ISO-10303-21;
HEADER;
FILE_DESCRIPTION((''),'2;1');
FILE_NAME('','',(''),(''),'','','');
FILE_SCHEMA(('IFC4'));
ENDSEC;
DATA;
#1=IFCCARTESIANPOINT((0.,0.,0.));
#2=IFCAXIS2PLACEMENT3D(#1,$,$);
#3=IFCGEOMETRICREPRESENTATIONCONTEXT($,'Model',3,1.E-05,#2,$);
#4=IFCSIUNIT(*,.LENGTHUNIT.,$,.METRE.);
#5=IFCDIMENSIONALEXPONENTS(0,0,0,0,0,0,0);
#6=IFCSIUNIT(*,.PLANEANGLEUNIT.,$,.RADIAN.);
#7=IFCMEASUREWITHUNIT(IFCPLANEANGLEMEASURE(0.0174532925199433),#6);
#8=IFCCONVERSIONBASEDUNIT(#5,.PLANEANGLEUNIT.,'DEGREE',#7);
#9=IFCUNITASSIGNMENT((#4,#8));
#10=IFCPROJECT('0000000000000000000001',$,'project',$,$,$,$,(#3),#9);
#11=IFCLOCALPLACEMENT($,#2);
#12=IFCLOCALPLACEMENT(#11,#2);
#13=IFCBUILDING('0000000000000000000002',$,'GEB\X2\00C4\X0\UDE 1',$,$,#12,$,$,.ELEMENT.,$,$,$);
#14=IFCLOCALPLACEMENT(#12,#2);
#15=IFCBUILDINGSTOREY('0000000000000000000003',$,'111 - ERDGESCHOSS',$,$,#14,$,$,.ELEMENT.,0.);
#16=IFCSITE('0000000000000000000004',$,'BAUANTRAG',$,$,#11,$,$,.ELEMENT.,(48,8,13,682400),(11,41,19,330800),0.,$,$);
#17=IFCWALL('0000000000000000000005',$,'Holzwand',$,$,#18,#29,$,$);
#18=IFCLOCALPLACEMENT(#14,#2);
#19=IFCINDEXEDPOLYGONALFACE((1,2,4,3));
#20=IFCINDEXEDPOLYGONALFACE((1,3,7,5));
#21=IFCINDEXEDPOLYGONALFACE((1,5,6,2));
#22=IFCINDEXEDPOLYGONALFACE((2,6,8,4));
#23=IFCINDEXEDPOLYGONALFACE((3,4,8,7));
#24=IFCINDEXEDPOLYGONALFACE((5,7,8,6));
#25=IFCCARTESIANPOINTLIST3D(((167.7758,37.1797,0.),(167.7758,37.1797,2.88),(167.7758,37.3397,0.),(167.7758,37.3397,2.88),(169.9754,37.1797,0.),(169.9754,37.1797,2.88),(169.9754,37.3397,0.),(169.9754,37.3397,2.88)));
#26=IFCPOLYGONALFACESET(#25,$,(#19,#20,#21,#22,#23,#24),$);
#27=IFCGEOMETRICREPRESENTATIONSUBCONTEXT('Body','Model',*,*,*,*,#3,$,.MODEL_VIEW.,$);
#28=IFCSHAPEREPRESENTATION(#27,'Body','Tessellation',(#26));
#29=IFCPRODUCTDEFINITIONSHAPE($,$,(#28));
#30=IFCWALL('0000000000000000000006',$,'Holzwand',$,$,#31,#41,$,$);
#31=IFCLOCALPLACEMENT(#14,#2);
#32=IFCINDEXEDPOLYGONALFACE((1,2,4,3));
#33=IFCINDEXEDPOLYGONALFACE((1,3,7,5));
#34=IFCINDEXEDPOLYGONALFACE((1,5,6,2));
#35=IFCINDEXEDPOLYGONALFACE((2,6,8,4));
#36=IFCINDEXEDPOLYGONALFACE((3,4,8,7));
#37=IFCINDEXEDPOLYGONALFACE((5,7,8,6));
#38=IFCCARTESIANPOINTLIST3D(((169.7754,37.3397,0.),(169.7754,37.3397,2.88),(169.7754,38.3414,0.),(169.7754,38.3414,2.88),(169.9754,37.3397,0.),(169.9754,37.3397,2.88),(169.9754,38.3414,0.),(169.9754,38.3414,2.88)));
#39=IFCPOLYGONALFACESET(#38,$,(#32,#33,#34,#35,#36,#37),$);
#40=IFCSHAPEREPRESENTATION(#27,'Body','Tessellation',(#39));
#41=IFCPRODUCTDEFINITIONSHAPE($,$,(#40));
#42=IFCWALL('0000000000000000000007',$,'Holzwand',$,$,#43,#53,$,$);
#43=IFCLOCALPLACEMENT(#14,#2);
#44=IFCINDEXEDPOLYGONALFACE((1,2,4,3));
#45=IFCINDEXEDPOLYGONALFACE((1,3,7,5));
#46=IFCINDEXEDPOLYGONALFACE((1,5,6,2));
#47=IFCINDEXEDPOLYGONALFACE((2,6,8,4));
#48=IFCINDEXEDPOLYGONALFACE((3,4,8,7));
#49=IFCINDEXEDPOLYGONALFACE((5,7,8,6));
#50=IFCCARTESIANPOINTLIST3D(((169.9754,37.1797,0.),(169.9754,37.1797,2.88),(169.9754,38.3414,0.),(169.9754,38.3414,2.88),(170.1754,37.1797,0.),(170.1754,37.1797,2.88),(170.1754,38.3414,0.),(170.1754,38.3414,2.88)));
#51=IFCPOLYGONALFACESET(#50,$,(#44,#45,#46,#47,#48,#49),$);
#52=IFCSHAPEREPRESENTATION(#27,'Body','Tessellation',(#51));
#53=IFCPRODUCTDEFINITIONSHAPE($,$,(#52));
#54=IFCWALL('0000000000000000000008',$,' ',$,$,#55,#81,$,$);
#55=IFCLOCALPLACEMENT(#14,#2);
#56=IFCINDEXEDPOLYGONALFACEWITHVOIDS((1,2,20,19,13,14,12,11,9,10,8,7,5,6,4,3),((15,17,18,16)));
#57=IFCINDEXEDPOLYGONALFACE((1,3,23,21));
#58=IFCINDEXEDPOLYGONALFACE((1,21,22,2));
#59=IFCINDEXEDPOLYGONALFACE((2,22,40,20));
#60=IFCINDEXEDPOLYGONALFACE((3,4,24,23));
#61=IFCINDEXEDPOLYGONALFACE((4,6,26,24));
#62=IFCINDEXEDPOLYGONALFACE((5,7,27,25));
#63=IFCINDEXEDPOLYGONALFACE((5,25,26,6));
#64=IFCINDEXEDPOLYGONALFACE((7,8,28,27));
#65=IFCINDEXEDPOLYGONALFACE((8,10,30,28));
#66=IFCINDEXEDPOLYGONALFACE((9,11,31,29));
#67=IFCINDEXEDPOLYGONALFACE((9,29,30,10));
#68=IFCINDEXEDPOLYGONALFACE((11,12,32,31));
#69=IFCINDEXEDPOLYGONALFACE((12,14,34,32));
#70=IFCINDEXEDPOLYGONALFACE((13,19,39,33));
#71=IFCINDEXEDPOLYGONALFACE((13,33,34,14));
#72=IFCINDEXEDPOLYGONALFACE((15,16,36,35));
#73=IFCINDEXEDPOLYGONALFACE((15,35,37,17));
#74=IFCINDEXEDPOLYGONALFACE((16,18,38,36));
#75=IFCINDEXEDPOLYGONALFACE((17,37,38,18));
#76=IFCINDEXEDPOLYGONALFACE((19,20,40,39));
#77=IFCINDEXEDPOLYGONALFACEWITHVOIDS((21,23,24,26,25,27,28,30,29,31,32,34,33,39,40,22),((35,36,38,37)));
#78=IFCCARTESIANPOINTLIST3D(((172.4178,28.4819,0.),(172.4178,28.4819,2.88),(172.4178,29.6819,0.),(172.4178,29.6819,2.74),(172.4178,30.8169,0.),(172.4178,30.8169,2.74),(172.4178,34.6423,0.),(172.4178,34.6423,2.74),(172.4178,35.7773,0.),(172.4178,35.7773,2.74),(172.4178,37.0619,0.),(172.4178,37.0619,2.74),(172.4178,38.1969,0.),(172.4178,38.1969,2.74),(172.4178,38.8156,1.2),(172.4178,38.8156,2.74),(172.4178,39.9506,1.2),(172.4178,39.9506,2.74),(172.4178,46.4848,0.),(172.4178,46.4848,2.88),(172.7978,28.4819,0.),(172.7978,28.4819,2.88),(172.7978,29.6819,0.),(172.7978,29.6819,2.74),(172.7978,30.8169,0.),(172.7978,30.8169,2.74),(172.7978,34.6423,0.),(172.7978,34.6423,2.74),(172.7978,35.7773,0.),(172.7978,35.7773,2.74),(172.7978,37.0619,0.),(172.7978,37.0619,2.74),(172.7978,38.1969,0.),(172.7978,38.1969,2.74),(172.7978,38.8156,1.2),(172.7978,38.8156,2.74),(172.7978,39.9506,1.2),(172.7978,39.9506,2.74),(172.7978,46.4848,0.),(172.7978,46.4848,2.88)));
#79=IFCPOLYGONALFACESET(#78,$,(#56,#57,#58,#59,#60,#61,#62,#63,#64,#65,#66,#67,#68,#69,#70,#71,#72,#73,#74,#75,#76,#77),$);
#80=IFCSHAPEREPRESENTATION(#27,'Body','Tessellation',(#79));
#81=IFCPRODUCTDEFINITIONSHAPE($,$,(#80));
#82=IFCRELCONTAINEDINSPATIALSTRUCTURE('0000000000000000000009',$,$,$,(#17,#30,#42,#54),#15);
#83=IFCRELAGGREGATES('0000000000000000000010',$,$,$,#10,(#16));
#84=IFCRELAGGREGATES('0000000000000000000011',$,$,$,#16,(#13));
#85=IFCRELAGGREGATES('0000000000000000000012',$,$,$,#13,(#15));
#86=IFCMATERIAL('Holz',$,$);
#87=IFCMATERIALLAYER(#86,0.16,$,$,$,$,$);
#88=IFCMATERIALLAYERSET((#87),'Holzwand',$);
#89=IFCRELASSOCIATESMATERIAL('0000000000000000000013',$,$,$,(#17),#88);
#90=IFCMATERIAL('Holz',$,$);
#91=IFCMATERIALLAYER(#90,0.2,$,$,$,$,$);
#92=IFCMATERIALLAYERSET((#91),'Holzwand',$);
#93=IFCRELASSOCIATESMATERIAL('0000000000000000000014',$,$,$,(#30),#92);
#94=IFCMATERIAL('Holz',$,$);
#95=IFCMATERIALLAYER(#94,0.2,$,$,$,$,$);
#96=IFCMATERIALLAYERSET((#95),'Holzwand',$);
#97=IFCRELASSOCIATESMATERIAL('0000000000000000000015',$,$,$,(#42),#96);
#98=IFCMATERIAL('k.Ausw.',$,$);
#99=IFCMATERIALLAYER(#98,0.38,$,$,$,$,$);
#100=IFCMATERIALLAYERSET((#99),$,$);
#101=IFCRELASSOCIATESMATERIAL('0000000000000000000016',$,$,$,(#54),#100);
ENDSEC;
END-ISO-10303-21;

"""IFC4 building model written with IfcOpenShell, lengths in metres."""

from ifc_helpers import new_model, entity, si_unit, converted_unit, frame, frame_2d, origin, origin_with_axes, place, context, subcontext, project, spatial, polyline, rectangle, outline, extrude, material, layer, layer_set, layer_usage, element, save


model = new_model("IFC4")

# Units and contexts
model_context = context("Model", 3, precision=1e-05, world=origin())
body_context = subcontext(model_context, "Body", "Model", "MODEL_VIEW")
ifc_project = project(units=[si_unit("LENGTHUNIT", "METRE"), converted_unit("PLANEANGLEUNIT", "DEGREE", entity("IfcPlaneAngleMeasure", 0.0174532925199433), si_unit("PLANEANGLEUNIT", "RADIAN"), dimensions=[0, 0, 0, 0, 0, 0, 0])], contexts=[model_context])

# Site, building, storey
site_placement = place(None, origin())
site = spatial("IfcSite", under=ifc_project, at=site_placement, Name="BAUANTRAG", CompositionType="ELEMENT", RefLatitude=(48, 8, 13, 682400), RefLongitude=(11, 41, 19, 330800), RefElevation=0.0)
building_placement = place(site_placement, origin())
building = spatial("IfcBuilding", under=site, at=building_placement, Name="GEBÄUDE 1", CompositionType="ELEMENT")
storey_placement = place(building_placement, origin())
storey = spatial("IfcBuildingStorey", under=building, at=storey_placement, Name="111 - ERDGESCHOSS", CompositionType="ELEMENT", Elevation=0.0)

# Walls
ifc_material_1 = material(Name="Holz")
ifc_layer_1 = layer(ifc_material_1, 0.16)
ifc_layer_set_1 = layer_set([ifc_layer_1], Name="Holzwand")
ifc_layer_usage_1 = layer_usage(ifc_layer_set_1, "AXIS2", "POSITIVE", 0.0)
wall_1_placement = place(storey_placement, frame((169.9754, 37.3397, 0.0), z_axis=(0.0, 0.0, 1.0), x_axis=(-1.0, 0.0, 0.0)))
element("IfcWall", 1, at=wall_1_placement, inside=storey, material=ifc_layer_usage_1, Name="Holzwand", context=body_context, shape_type="SweptSolid", body=[
    extrude(rectangle(XDim=2.1997, YDim=0.16, at=frame_2d((1.0998, 0.08), x_axis=(1.0, 0.0))), origin_with_axes(), (0.0, 0.0, 1.0), 2.88),
])
ifc_material_2 = material(Name="Holz")
ifc_layer_2 = layer(ifc_material_2, 0.2)
ifc_layer_set_2 = layer_set([ifc_layer_2], Name="Holzwand")
ifc_layer_usage_2 = layer_usage(ifc_layer_set_2, "AXIS2", "POSITIVE", 0.0)
wall_2_placement = place(storey_placement, frame((169.9754, 37.3397, 0.0), z_axis=(0.0, 0.0, 1.0), x_axis=(0.0, 1.0, 0.0)))
element("IfcWall", 2, at=wall_2_placement, inside=storey, material=ifc_layer_usage_2, Name="Holzwand", context=body_context, shape_type="SweptSolid", body=[
    extrude(rectangle(XDim=1.0017, YDim=0.2, at=frame_2d((0.5008, 0.1), x_axis=(1.0, 0.0))), origin_with_axes(), (0.0, 0.0, 1.0), 2.88),
])
ifc_material_3 = material(Name="Holz")
ifc_layer_3 = layer(ifc_material_3, 0.2)
ifc_layer_set_3 = layer_set([ifc_layer_3], Name="Holzwand")
ifc_layer_usage_3 = layer_usage(ifc_layer_set_3, "AXIS2", "POSITIVE", 0.0)
wall_3_placement = place(storey_placement, frame((170.1754, 37.1797, 0.0), z_axis=(0.0, 0.0, 1.0), x_axis=(0.0, 1.0, 0.0)))
element("IfcWall", 3, at=wall_3_placement, inside=storey, material=ifc_layer_usage_3, Name="Holzwand", context=body_context, shape_type="SweptSolid", body=[
    extrude(rectangle(XDim=1.1617, YDim=0.2, at=frame_2d((0.5808, 0.1), x_axis=(1.0, 0.0))), origin_with_axes(), (0.0, 0.0, 1.0), 2.88),
])

# Wall, openings
ifc_material_4 = material(Name="k.Ausw.")
ifc_layer_4 = layer(ifc_material_4, 0.38)
ifc_layer_set_4 = layer_set([ifc_layer_4])
ifc_layer_usage_4 = layer_usage(ifc_layer_set_4, "AXIS2", "POSITIVE", 0.0)
wall_4_placement = place(storey_placement, frame((172.7978, 28.4819, 0.0), z_axis=(0.0, 0.0, 1.0), x_axis=(0.0, 1.0, 0.0)))
wall_4 = element("IfcWall", 4, at=wall_4_placement, inside=storey, material=ifc_layer_usage_4, Name=" ", context=body_context, shape_type="SweptSolid", body=[
    extrude(rectangle(XDim=18.0029, YDim=0.38, at=frame_2d((9.0014, 0.19), x_axis=(1.0, 0.0))), origin_with_axes(), (0.0, 0.0, 1.0), 2.88),
])
opening_1_placement = place(wall_4_placement, frame((10.3337, 0.0, 1.2), z_axis=(0.0, 1.0, 0.0), x_axis=(0.0, 0.0, 1.0)))
element("IfcOpeningElement", 5, at=opening_1_placement, cuts=wall_4, ObjectType="Opening", context=body_context, shape_type="SweptSolid", body=[
    extrude(outline(polyline([(0.0, 1.135), (1.54, 1.135), (1.54, 0.0), (0.0, 0.0), (0.0, 1.135)])), origin_with_axes(), (0.0, 0.0, 1.0), 0.38),
])
opening_2_placement = place(wall_4_placement, frame((8.58, 0.0, 0.0), z_axis=(0.0, 1.0, 0.0), x_axis=(0.0, 0.0, 1.0)))
element("IfcOpeningElement", 6, at=opening_2_placement, cuts=wall_4, ObjectType="Opening", context=body_context, shape_type="SweptSolid", body=[
    extrude(outline(polyline([(0.0, 1.135), (2.74, 1.135), (2.74, 0.0), (0.0, 0.0), (0.0, 1.135)])), origin_with_axes(), (0.0, 0.0, 1.0), 0.38),
])
opening_3_placement = place(wall_4_placement, frame((6.1604, 0.0, 0.0), z_axis=(0.0, 1.0, 0.0), x_axis=(0.0, 0.0, 1.0)))
element("IfcOpeningElement", 7, at=opening_3_placement, cuts=wall_4, ObjectType="Opening", context=body_context, shape_type="SweptSolid", body=[
    extrude(outline(polyline([(0.0, 1.135), (2.74, 1.135), (2.74, 0.0), (0.0, 0.0), (0.0, 1.135)])), origin_with_axes(), (0.0, 0.0, 1.0), 0.38),
])
opening_4_placement = place(wall_4_placement, frame((1.2, 0.0, 0.0), z_axis=(0.0, 1.0, 0.0), x_axis=(0.0, 0.0, 1.0)))
element("IfcOpeningElement", 8, at=opening_4_placement, cuts=wall_4, ObjectType="Opening", context=body_context, shape_type="SweptSolid", body=[
    extrude(outline(polyline([(0.0, 1.135), (2.74, 1.135), (2.74, 0.0), (0.0, 0.0), (0.0, 1.135)])), origin_with_axes(), (0.0, 0.0, 1.0), 0.38),
])

save(model, "model.ifc")
